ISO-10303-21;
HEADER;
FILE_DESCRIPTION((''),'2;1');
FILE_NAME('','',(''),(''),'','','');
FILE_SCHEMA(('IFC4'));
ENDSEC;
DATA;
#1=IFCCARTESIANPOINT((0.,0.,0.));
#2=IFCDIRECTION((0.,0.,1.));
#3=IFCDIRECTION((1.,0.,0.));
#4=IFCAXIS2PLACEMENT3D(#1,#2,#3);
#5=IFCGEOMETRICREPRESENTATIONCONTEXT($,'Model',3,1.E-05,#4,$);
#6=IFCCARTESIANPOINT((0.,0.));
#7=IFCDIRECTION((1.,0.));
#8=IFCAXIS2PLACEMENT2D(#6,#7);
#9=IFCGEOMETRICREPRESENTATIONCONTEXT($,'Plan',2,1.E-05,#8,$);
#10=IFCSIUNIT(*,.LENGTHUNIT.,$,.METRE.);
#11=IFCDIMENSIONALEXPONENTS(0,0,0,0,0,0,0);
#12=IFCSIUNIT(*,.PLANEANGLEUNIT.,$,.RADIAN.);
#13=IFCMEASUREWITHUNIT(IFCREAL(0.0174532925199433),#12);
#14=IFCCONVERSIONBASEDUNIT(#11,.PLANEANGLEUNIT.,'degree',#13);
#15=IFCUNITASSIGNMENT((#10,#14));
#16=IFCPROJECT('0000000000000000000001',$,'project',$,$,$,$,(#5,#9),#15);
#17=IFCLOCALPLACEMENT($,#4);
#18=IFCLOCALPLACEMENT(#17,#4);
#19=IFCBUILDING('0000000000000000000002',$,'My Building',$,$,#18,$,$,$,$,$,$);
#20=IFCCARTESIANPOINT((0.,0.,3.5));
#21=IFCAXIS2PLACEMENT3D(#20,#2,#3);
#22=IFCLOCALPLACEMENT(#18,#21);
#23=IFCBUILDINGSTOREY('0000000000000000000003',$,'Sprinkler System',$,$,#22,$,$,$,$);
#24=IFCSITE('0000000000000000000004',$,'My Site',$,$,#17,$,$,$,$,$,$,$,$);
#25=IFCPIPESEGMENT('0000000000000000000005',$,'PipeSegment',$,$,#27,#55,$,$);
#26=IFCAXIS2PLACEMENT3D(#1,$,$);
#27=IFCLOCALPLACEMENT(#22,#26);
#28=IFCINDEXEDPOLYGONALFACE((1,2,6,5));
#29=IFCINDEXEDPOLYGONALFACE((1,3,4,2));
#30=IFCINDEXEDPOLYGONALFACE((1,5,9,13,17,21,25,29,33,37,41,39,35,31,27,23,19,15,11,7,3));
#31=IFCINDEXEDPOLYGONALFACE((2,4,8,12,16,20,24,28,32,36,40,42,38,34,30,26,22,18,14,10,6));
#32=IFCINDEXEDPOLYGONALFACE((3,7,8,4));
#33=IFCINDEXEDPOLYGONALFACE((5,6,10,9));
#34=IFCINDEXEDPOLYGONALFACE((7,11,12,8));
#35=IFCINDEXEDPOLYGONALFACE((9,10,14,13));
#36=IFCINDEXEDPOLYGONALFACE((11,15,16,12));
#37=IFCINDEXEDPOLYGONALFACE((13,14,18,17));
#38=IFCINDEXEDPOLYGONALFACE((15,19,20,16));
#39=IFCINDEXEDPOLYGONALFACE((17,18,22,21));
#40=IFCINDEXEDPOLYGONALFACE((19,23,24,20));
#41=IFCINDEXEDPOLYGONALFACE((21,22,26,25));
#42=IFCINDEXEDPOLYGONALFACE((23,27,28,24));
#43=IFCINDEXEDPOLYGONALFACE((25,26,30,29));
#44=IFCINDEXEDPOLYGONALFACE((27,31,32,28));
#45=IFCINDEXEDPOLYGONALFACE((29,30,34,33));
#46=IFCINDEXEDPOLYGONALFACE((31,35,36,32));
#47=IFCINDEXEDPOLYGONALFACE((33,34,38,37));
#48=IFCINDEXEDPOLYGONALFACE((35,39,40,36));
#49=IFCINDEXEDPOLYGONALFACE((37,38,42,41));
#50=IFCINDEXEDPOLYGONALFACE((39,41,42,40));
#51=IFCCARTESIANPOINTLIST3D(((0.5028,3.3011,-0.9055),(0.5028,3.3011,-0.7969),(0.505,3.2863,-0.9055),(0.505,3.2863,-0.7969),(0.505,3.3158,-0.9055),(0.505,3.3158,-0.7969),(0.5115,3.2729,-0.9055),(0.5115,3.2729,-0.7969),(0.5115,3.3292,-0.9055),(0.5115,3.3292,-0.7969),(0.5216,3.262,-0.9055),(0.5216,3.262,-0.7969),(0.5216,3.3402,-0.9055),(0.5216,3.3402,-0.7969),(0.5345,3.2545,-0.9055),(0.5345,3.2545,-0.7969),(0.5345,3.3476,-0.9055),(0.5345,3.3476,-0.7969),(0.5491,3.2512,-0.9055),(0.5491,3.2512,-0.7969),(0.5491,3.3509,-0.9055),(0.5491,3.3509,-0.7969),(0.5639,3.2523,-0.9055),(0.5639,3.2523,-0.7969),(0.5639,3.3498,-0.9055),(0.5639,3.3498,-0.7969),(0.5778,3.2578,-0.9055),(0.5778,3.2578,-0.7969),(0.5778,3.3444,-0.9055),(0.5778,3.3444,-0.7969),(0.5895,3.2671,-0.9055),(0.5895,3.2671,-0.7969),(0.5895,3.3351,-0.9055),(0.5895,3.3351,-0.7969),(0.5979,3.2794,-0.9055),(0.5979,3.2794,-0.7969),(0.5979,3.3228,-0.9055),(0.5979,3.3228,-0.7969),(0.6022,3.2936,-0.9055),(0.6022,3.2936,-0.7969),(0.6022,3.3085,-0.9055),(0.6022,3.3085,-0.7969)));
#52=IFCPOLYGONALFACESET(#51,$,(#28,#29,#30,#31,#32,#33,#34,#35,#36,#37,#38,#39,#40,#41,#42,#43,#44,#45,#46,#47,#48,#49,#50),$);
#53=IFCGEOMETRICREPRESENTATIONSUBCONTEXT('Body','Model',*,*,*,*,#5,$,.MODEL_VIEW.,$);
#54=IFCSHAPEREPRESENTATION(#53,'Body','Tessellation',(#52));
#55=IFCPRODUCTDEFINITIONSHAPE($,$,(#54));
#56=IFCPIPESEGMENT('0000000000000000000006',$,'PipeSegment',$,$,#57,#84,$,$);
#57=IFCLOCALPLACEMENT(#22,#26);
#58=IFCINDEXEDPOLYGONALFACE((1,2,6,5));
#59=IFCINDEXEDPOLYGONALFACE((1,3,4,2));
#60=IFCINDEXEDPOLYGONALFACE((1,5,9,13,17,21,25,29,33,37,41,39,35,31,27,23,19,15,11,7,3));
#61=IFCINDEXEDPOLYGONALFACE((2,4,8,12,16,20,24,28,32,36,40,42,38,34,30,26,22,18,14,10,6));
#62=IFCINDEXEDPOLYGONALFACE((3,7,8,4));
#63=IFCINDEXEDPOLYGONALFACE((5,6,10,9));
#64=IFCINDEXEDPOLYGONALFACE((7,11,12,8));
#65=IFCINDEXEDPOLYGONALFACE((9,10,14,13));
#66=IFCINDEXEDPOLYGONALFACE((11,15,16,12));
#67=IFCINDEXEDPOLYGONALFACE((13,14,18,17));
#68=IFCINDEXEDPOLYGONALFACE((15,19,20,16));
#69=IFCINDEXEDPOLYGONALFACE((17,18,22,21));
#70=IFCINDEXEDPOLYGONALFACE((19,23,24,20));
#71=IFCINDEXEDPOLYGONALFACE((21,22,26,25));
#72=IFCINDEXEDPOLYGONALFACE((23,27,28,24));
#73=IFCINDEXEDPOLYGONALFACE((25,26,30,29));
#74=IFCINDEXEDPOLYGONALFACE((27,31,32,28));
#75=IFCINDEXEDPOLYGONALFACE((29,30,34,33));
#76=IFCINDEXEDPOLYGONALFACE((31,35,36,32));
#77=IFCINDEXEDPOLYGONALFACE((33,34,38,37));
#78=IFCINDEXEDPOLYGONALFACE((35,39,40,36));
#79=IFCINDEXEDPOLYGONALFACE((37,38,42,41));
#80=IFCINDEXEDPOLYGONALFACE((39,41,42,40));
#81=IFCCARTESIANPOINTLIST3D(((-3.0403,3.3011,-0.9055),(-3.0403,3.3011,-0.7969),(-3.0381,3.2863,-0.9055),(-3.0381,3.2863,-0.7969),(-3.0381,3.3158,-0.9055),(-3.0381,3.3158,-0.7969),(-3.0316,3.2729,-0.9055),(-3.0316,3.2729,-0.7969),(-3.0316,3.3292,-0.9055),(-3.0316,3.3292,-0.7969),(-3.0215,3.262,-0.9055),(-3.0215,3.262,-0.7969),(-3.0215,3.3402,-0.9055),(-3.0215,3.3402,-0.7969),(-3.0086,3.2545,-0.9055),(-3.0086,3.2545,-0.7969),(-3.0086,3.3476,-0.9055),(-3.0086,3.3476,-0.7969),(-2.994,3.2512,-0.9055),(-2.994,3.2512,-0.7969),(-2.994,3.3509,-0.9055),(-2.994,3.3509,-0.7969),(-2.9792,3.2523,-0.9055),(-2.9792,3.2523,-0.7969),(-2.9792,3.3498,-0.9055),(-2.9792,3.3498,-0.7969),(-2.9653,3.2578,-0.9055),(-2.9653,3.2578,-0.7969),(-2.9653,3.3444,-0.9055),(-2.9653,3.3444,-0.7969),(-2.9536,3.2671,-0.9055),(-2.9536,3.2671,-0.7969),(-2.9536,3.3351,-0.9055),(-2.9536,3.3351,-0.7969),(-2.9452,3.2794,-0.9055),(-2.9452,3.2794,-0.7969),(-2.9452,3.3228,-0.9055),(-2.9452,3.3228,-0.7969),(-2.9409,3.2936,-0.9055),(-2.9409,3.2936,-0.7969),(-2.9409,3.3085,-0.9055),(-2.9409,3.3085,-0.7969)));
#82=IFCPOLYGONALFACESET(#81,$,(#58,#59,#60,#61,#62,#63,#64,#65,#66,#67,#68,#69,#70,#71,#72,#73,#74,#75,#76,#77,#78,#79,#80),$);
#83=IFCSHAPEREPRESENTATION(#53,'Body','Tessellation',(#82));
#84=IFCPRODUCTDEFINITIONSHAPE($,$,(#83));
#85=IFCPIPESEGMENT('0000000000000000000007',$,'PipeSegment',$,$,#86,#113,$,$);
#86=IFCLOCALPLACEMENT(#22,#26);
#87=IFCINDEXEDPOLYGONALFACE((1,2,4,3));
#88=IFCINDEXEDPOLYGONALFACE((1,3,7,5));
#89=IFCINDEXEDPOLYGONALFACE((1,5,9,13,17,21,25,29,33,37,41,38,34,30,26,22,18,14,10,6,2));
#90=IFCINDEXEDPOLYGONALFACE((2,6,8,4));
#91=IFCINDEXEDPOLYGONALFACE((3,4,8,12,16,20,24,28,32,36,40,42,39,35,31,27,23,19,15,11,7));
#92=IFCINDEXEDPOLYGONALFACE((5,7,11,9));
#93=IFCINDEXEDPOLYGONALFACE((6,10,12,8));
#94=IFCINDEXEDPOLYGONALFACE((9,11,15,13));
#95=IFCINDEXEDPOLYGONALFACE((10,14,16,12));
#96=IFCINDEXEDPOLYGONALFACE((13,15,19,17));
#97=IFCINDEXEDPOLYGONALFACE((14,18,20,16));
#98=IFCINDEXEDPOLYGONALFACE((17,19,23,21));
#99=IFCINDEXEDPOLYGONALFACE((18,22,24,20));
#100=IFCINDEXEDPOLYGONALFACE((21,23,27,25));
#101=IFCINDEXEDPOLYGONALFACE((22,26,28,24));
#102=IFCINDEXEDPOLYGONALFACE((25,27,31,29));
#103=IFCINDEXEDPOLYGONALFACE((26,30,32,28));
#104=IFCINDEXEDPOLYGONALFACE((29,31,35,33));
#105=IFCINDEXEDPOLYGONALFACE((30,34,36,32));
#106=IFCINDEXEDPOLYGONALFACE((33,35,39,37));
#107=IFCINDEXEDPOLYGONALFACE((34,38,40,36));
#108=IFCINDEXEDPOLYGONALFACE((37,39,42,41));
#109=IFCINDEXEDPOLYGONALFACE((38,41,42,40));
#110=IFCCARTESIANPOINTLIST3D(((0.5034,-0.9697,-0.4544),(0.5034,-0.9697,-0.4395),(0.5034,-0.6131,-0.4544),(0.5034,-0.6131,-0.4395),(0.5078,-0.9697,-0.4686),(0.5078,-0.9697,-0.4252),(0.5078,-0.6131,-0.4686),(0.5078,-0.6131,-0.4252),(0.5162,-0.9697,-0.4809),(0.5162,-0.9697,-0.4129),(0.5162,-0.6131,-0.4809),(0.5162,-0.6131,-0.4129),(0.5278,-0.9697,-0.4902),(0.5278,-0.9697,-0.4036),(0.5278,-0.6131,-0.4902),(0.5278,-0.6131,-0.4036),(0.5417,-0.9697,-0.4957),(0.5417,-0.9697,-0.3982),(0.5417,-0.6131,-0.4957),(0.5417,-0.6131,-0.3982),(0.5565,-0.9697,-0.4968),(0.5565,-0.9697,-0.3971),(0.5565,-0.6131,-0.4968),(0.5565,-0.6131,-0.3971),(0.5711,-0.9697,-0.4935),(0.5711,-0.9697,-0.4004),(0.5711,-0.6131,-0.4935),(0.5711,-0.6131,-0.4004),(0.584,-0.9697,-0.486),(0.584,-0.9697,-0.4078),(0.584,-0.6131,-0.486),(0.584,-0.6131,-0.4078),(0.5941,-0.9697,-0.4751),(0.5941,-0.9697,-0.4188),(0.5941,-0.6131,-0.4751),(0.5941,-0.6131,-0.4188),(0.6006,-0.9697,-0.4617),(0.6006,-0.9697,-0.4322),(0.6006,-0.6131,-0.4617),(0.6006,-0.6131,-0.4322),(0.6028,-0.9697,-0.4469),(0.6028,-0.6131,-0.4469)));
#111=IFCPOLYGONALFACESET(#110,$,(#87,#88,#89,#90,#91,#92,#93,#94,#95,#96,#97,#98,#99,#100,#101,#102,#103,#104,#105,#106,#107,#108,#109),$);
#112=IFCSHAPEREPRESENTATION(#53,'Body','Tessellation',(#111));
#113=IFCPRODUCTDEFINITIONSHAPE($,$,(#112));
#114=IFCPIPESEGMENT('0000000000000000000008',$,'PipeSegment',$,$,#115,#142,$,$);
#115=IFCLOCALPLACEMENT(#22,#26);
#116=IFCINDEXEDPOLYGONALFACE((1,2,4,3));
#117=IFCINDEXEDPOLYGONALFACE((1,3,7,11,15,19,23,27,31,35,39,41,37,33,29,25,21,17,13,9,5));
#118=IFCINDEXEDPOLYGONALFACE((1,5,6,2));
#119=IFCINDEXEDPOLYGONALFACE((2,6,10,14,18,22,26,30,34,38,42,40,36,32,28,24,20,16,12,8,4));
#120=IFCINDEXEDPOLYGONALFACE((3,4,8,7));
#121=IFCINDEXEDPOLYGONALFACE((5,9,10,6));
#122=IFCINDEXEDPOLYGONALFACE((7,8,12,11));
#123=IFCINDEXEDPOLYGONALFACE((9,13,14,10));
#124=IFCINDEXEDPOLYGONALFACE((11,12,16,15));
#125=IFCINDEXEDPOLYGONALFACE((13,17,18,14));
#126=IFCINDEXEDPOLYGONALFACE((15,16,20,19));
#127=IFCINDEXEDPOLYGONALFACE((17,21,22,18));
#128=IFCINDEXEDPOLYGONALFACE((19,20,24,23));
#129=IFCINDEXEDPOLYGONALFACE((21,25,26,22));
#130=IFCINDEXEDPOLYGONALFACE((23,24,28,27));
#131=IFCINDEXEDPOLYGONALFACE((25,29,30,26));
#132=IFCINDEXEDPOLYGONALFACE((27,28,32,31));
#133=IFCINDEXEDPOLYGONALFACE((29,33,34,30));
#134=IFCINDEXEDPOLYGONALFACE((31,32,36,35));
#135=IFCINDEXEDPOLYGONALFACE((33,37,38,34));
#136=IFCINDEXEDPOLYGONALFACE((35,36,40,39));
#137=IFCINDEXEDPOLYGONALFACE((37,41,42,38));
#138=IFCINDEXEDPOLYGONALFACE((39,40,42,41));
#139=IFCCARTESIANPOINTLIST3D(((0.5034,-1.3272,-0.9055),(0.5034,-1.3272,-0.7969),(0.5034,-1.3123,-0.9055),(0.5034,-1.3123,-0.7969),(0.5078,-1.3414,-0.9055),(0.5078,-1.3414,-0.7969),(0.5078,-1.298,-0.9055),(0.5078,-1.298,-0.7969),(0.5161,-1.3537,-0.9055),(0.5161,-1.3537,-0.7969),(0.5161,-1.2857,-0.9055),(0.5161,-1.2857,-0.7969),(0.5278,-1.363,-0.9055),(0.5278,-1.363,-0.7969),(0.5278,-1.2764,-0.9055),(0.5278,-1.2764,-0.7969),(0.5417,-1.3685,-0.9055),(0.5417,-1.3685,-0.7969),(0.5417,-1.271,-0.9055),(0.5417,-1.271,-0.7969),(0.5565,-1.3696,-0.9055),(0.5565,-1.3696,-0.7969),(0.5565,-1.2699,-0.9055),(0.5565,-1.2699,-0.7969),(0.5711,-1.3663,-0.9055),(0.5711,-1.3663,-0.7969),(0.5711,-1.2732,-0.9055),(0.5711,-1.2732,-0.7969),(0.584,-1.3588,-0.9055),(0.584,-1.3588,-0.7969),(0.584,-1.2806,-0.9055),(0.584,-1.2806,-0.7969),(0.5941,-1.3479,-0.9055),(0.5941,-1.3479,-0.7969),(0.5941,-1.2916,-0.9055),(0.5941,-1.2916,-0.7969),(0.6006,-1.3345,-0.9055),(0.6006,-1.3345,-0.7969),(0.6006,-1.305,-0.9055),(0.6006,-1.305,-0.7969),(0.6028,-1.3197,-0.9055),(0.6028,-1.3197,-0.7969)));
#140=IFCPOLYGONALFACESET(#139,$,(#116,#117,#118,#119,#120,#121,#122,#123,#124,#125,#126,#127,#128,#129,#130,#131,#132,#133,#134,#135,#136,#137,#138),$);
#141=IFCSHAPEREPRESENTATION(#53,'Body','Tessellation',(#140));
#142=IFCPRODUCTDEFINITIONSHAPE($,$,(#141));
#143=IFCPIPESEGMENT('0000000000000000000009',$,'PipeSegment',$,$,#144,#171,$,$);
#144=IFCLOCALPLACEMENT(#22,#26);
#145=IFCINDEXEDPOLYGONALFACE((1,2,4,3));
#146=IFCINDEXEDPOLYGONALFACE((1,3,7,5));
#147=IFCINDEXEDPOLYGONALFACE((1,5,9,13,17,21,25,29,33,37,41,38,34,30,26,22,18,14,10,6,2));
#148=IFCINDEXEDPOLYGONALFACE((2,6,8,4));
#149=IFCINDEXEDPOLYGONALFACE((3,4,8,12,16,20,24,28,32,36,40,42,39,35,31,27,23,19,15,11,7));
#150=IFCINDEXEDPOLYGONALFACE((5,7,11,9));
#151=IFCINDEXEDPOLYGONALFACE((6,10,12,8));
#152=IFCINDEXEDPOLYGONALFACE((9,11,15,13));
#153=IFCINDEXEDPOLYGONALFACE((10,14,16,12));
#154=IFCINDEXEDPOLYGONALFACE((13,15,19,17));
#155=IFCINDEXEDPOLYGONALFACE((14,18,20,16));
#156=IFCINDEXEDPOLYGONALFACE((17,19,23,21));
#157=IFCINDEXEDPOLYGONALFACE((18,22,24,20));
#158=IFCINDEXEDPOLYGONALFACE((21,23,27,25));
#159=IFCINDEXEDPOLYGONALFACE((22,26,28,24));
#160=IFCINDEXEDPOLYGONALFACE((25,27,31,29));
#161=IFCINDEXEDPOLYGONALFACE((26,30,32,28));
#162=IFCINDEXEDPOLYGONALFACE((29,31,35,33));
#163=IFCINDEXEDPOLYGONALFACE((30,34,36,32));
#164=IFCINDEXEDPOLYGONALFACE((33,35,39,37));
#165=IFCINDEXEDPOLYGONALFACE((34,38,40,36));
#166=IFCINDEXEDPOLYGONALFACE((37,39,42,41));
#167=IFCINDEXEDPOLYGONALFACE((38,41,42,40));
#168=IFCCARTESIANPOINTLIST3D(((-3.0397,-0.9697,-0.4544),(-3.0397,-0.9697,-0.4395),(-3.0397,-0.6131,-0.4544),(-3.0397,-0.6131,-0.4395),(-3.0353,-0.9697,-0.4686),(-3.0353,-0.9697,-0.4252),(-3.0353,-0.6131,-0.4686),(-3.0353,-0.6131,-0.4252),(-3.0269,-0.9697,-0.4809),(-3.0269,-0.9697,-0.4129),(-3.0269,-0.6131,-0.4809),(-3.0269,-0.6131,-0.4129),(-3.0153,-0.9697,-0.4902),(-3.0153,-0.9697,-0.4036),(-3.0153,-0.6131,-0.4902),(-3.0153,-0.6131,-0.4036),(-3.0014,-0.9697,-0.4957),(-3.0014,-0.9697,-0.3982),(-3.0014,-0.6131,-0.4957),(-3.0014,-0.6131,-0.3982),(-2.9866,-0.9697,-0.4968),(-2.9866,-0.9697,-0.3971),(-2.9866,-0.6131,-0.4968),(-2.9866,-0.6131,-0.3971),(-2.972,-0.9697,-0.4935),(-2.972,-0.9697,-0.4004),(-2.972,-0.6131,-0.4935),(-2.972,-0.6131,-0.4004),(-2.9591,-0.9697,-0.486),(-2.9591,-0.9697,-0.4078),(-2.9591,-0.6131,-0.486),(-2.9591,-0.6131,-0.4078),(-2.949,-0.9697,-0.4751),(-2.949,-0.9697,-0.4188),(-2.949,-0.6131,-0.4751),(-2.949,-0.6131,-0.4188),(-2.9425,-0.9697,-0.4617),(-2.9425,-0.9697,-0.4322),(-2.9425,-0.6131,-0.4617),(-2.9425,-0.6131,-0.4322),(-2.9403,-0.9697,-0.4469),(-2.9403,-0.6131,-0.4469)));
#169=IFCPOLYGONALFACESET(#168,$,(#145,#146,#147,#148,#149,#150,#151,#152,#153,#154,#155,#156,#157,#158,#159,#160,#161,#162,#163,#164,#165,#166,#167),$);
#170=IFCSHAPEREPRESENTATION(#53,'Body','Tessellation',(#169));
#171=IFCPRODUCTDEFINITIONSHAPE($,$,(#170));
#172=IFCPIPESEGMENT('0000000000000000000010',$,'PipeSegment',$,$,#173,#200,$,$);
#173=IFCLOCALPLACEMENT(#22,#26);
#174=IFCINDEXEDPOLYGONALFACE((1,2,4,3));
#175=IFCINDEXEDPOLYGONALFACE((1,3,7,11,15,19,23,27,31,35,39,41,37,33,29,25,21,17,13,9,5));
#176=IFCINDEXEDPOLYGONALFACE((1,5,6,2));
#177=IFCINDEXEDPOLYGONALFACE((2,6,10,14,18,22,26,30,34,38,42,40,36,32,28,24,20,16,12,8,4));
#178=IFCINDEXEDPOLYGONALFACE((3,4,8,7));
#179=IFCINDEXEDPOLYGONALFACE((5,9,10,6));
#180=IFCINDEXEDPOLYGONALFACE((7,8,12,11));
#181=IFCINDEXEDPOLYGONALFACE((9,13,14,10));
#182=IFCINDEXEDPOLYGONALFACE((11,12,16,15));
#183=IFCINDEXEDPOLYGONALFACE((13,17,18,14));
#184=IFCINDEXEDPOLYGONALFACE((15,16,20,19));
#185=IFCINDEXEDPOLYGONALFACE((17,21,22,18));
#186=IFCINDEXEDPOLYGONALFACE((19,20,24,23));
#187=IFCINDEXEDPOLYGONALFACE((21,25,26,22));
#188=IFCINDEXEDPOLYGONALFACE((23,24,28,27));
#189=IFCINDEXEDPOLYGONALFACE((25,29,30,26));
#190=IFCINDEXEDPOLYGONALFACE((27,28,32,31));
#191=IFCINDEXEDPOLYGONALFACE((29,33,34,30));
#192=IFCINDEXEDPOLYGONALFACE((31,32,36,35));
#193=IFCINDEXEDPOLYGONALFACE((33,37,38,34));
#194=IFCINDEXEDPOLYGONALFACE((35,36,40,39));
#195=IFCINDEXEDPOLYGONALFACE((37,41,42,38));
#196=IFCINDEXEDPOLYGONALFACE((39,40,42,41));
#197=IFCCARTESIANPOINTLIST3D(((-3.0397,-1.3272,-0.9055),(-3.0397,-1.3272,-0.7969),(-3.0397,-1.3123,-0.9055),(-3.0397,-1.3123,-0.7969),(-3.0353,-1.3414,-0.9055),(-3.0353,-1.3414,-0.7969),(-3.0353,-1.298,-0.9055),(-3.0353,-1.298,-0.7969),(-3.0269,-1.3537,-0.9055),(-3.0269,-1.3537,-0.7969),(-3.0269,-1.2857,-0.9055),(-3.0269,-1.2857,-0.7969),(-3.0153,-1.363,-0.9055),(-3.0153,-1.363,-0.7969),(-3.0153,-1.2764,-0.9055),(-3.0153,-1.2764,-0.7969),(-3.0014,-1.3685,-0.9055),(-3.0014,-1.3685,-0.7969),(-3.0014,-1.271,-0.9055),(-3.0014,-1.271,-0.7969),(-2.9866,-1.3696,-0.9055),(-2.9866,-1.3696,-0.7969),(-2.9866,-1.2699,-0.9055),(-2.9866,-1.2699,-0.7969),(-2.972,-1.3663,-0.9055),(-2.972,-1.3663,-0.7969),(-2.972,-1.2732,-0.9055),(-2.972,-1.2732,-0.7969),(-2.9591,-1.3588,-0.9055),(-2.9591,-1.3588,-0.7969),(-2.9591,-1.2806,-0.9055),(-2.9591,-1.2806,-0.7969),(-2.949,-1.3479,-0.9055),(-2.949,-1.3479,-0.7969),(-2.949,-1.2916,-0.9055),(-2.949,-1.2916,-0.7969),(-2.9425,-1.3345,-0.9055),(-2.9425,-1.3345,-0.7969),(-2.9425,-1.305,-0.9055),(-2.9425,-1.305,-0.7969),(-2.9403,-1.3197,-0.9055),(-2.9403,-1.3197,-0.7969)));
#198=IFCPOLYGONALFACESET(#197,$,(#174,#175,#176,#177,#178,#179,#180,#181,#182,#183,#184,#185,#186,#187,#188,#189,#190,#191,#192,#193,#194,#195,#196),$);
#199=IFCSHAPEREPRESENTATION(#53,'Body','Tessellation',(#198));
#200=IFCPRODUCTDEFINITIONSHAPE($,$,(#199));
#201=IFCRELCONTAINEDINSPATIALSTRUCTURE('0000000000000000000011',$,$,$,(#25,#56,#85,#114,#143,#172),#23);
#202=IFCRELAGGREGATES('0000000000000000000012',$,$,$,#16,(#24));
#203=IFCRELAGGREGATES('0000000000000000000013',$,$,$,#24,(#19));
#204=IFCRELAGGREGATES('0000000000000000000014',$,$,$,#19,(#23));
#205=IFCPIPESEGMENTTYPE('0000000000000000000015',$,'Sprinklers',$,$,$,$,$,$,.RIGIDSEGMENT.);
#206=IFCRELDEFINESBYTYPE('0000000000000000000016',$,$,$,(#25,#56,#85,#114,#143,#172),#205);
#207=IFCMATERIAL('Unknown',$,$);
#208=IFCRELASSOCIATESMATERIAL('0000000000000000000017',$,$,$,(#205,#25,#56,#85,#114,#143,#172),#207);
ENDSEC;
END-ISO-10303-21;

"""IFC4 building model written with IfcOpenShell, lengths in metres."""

from ifc_helpers import new_model, entity, si_unit, converted_unit, frame, origin_with_axes, origin_2d_with_axis, place, context, subcontext, project, spatial, circle, extrude, material, material_profile, profile_set, profile_usage, type_object, element, save


model = new_model("IFC4")

# Units and contexts
model_context = context("Model", 3, precision=1e-05, world=origin_with_axes())
plan_context = context("Plan", 2, precision=1e-05, world=origin_2d_with_axis())
body_context = subcontext(model_context, "Body", "Model", "MODEL_VIEW")
ifc_project = project(units=[si_unit("LENGTHUNIT", "METRE"), converted_unit("PLANEANGLEUNIT", "degree", entity("IfcReal", 0.0174532925199433), si_unit("PLANEANGLEUNIT", "RADIAN"), dimensions=[0, 0, 0, 0, 0, 0, 0])], contexts=[model_context, plan_context])

# Site, building, storey
site_placement = place(None, origin_with_axes())
site = spatial("IfcSite", under=ifc_project, at=site_placement, Name="My Site")
building_placement = place(site_placement, origin_with_axes())
building = spatial("IfcBuilding", under=site, at=building_placement, Name="My Building")
storey_placement = place(building_placement, frame((0.0, 0.0, 3.5), z_axis=(0.0, 0.0, 1.0), x_axis=(1.0, 0.0, 0.0)))
storey = spatial("IfcBuildingStorey", under=building, at=storey_placement, Name="Sprinkler System")

# Pipe segments
ifc_material = material(Name="Unknown")
ifc_material_profile_1 = material_profile(ifc_material, circle(Radius=0.05))
ifc_profile_set_1 = profile_set([ifc_material_profile_1])
pipe_segment_type = type_object("IfcPipeSegmentType", Name="Sprinklers", PredefinedType="RIGIDSEGMENT", material=ifc_profile_set_1)
ifc_profile_usage_1 = profile_usage(ifc_profile_set_1, cardinal=5)
pipe_segment_1_placement = place(storey_placement, frame((0.5528, 3.3011, -0.7969), z_axis=(0.0, 0.000034, -1.0), x_axis=(-1.0, 0.0, 0.0)))
element("IfcPipeSegment", 1, at=pipe_segment_1_placement, inside=storey, type_object=pipe_segment_type, material=ifc_profile_usage_1, Name="PipeSegment", context=body_context, shape_type="SweptSolid", body=[
    extrude(circle(Radius=0.05), origin_with_axes(), (0.0, 0.0, 1.0), 0.1086),
])
ifc_profile_usage_2 = profile_usage(ifc_profile_set_1, cardinal=5)
pipe_segment_2_placement = place(storey_placement, frame((-2.9903, 3.3011, -0.7969), z_axis=(0.0, 0.000034, -1.0), x_axis=(-1.0, 0.0, 0.0)))
element("IfcPipeSegment", 2, at=pipe_segment_2_placement, inside=storey, type_object=pipe_segment_type, material=ifc_profile_usage_2, Name="PipeSegment", context=body_context, shape_type="SweptSolid", body=[
    extrude(circle(Radius=0.05), origin_with_axes(), (0.0, 0.0, 1.0), 0.1086),
])
ifc_profile_usage_3 = profile_usage(ifc_profile_set_1, cardinal=5)
pipe_segment_3_placement = place(storey_placement, frame((0.5528, -0.6131, -0.4469), z_axis=(0.0, -1.0, -0.00001), x_axis=(1.0, 0.0, 0.0)))
element("IfcPipeSegment", 3, at=pipe_segment_3_placement, inside=storey, type_object=pipe_segment_type, material=ifc_profile_usage_3, Name="PipeSegment", context=body_context, shape_type="SweptSolid", body=[
    extrude(circle(Radius=0.05), origin_with_axes(), (0.0, 0.0, 1.0), 0.3566),
])
ifc_profile_usage_4 = profile_usage(ifc_profile_set_1, cardinal=5)
pipe_segment_4_placement = place(storey_placement, frame((0.5528, -1.3197, -0.7969), z_axis=(0.0, -0.000034, -1.0), x_axis=(1.0, -0.000001, 0.0)))
element("IfcPipeSegment", 4, at=pipe_segment_4_placement, inside=storey, type_object=pipe_segment_type, material=ifc_profile_usage_4, Name="PipeSegment", context=body_context, shape_type="SweptSolid", body=[
    extrude(circle(Radius=0.05), origin_with_axes(), (0.0, 0.0, 1.0), 0.1086),
])
ifc_profile_usage_5 = profile_usage(ifc_profile_set_1, cardinal=5)
pipe_segment_5_placement = place(storey_placement, frame((-2.9903, -0.6131, -0.4469), z_axis=(0.0, -1.0, -0.00001), x_axis=(1.0, 0.0, 0.0)))
element("IfcPipeSegment", 5, at=pipe_segment_5_placement, inside=storey, type_object=pipe_segment_type, material=ifc_profile_usage_5, Name="PipeSegment", context=body_context, shape_type="SweptSolid", body=[
    extrude(circle(Radius=0.05), origin_with_axes(), (0.0, 0.0, 1.0), 0.3566),
])
ifc_profile_usage_6 = profile_usage(ifc_profile_set_1, cardinal=5)
pipe_segment_6_placement = place(storey_placement, frame((-2.9903, -1.3197, -0.7969), z_axis=(0.0, -0.000034, -1.0), x_axis=(1.0, -0.000001, 0.0)))
element("IfcPipeSegment", 6, at=pipe_segment_6_placement, inside=storey, type_object=pipe_segment_type, material=ifc_profile_usage_6, Name="PipeSegment", context=body_context, shape_type="SweptSolid", body=[
    extrude(circle(Radius=0.05), origin_with_axes(), (0.0, 0.0, 1.0), 0.1086),
])

save(model, "model.ifc")
